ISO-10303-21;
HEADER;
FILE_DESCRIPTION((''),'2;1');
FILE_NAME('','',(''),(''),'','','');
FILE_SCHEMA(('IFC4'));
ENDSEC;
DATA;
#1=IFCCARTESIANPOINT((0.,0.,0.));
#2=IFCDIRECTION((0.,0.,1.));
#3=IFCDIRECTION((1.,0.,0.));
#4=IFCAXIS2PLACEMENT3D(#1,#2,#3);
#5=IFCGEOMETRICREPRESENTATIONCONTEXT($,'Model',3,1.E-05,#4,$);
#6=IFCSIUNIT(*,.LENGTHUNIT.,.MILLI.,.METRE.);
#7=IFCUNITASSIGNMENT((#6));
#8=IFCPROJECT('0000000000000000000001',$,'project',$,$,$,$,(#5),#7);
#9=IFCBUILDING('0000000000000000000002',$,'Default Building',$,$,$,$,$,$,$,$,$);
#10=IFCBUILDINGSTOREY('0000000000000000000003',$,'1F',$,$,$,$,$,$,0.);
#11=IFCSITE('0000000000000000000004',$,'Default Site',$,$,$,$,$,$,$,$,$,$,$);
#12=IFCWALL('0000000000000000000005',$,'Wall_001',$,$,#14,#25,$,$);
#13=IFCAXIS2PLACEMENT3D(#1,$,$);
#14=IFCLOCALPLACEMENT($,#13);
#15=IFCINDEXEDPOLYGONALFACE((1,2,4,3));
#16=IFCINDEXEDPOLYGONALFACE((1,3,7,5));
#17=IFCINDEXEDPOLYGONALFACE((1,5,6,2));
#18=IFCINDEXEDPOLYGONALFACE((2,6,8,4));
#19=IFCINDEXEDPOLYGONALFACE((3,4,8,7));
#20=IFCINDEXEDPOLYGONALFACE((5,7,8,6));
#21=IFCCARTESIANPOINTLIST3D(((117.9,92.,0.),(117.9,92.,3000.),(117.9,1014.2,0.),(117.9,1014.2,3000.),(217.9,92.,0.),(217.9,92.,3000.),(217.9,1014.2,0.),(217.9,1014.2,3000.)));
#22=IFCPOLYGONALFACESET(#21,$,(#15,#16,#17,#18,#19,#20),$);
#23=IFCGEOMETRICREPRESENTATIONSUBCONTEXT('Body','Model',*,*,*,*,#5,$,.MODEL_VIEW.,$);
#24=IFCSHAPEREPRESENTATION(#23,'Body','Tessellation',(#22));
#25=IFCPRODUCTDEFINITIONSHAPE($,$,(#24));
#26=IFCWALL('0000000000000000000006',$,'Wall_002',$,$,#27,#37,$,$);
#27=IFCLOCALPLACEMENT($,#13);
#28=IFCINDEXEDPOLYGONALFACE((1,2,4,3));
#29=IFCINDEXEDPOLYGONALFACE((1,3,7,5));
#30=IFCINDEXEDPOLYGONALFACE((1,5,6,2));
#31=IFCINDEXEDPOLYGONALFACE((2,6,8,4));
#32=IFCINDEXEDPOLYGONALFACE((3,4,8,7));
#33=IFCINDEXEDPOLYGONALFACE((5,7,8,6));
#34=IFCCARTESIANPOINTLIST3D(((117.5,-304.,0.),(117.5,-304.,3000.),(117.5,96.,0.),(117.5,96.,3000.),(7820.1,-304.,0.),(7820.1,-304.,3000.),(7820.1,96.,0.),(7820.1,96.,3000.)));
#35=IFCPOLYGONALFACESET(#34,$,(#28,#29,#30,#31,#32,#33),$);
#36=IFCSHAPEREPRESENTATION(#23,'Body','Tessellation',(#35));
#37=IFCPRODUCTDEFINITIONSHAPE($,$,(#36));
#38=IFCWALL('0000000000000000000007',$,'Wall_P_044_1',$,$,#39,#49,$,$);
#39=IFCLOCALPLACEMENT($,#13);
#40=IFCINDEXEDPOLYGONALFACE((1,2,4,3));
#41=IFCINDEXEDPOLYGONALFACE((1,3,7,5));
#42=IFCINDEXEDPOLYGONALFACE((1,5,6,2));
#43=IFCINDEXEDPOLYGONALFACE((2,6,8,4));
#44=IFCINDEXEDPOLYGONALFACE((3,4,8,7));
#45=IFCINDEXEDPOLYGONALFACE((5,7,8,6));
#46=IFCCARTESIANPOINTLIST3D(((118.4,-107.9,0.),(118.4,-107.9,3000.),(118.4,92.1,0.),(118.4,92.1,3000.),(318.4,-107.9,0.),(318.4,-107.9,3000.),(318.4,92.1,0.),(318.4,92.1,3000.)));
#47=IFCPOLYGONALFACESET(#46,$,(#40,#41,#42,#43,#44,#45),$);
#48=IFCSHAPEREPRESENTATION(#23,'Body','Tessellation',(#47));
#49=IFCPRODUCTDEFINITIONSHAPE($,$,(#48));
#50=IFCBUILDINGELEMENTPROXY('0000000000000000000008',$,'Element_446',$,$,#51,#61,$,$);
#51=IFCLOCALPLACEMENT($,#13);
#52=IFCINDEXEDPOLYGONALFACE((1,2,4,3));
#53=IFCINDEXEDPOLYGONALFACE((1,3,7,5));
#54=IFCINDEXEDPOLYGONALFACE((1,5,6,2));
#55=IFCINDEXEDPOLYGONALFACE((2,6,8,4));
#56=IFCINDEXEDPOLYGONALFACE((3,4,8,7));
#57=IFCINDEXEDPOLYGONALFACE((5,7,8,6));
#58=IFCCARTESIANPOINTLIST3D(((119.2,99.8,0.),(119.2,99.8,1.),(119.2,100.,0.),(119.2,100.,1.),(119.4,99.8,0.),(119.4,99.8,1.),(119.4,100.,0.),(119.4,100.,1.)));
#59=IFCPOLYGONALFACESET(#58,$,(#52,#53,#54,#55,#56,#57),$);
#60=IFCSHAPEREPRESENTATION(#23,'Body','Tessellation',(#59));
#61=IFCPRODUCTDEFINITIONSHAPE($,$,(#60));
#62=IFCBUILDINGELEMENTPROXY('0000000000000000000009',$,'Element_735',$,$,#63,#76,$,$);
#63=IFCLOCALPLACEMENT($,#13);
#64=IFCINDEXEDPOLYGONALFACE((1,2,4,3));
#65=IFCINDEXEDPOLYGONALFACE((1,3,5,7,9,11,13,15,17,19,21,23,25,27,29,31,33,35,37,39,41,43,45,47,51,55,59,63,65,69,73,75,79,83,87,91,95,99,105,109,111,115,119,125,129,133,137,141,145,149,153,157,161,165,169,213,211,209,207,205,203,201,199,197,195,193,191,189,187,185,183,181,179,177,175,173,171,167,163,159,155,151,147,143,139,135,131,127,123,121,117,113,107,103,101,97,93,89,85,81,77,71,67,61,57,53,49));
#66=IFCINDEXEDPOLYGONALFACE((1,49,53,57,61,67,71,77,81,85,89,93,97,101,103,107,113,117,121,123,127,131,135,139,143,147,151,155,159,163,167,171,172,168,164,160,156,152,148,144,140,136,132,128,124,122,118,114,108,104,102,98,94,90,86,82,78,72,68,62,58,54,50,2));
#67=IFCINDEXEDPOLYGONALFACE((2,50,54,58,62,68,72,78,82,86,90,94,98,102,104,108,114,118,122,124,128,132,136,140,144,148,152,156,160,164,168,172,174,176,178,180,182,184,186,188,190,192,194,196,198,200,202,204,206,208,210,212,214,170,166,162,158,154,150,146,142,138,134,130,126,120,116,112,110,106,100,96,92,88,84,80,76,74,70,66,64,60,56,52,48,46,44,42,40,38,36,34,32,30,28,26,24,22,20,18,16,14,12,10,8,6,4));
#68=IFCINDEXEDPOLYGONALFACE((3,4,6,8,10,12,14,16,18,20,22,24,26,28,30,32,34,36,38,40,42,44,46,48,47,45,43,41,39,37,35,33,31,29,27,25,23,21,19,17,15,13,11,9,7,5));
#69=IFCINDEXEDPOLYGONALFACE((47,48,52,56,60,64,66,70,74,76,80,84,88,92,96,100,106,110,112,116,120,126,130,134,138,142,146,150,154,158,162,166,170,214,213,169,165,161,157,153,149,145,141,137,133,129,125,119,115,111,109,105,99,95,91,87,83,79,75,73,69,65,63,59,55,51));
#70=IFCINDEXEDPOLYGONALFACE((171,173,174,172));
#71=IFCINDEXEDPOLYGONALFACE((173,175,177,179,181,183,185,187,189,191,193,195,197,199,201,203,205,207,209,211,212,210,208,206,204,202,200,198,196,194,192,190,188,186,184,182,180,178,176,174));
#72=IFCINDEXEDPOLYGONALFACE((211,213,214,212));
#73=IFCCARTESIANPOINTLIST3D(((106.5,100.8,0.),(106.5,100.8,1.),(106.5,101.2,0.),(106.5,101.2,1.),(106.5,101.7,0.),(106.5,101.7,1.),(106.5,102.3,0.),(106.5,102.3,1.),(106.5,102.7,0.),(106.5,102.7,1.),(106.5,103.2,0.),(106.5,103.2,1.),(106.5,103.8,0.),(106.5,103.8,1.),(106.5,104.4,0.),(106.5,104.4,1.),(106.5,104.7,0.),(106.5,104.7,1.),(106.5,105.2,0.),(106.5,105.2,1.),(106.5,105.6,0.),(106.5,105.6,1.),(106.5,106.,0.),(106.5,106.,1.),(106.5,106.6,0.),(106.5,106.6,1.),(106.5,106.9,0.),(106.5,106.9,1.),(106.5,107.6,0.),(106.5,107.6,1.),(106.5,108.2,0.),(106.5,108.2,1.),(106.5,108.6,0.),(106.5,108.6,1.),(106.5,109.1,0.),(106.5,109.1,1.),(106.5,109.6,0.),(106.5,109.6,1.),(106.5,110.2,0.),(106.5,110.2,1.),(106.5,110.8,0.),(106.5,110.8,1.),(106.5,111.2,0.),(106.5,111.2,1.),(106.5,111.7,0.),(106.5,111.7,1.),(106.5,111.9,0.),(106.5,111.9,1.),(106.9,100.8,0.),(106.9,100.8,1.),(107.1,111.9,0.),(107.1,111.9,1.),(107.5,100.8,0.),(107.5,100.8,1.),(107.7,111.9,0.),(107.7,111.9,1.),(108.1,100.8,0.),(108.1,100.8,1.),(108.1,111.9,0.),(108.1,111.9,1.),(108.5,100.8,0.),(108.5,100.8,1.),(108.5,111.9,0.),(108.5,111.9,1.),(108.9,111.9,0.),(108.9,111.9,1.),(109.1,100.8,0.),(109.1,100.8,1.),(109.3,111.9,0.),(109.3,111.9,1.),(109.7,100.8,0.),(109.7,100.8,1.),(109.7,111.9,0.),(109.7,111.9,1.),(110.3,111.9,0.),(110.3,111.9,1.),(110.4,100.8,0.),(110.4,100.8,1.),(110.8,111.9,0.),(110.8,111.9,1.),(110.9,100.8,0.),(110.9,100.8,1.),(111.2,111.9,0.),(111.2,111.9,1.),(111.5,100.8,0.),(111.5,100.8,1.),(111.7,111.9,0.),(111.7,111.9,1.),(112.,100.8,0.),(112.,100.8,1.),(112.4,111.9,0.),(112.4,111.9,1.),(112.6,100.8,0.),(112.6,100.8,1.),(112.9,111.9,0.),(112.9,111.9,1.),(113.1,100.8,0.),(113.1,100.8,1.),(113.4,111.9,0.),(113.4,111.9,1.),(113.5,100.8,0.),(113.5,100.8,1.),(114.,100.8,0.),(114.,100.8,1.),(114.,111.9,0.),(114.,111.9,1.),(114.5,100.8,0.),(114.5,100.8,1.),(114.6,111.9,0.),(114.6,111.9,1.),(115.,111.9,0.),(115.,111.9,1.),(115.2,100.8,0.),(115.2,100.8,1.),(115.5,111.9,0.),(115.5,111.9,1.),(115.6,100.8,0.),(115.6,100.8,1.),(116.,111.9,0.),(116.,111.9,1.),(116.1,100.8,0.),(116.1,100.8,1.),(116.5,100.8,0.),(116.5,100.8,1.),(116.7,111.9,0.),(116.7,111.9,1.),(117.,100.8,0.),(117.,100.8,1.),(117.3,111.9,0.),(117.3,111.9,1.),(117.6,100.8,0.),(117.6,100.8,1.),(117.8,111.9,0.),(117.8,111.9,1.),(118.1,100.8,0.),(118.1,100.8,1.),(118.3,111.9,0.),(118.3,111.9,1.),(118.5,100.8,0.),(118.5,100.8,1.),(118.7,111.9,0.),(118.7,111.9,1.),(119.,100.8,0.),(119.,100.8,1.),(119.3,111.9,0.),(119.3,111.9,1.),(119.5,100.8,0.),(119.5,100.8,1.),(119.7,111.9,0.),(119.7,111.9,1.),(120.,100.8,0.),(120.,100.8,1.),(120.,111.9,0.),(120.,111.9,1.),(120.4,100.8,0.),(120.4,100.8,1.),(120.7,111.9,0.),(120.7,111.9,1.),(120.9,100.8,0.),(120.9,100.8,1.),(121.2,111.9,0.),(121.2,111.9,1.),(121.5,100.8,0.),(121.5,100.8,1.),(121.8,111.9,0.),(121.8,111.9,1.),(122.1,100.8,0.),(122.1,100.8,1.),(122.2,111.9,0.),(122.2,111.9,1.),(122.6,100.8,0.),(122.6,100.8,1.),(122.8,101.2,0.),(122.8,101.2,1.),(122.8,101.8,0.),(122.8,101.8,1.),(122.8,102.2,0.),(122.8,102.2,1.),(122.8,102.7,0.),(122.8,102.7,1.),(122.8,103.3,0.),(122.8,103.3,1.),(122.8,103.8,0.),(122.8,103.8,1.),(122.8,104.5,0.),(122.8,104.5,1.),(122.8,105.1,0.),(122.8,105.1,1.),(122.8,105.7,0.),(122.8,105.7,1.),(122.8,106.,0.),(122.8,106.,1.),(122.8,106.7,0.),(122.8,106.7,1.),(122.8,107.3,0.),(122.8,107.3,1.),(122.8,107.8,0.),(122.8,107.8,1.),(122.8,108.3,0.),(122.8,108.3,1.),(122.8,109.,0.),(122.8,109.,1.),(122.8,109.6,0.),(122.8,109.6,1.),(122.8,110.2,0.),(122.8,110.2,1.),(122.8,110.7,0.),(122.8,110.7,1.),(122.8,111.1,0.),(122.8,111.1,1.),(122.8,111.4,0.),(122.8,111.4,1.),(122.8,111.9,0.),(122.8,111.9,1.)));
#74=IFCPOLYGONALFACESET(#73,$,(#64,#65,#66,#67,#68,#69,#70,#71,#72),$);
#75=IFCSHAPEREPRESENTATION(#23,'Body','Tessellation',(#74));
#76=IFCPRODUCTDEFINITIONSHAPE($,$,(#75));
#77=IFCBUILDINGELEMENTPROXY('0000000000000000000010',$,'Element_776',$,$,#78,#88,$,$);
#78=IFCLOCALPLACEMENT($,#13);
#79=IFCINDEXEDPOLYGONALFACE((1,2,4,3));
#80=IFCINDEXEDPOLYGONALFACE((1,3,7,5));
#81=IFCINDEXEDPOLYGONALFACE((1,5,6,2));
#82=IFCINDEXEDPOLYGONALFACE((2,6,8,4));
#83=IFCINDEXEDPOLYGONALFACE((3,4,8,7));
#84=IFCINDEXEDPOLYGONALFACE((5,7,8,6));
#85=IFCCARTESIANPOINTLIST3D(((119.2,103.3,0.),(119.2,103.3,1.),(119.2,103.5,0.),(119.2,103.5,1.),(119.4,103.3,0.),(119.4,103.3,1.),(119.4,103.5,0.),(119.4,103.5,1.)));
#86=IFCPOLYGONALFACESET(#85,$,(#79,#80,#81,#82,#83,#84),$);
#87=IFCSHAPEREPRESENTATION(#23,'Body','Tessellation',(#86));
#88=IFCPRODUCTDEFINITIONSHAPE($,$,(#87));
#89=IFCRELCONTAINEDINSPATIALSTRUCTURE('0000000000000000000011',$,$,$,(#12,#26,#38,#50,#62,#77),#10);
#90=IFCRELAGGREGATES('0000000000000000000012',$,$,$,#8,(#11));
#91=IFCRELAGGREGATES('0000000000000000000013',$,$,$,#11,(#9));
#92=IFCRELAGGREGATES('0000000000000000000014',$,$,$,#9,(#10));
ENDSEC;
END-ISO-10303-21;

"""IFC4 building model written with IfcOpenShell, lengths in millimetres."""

from ifc_helpers import new_model, si_unit, frame, origin, origin_with_axes, place, context, subcontext, project, spatial, polyline, indexed_curve, outline, extrude, element, save


model = new_model("IFC4")

# Units and contexts
model_context = context("Model", 3, precision=1e-05, world=origin_with_axes())
body_context = subcontext(model_context, "Body", "Model", "MODEL_VIEW")
ifc_project = project(units=[si_unit("LENGTHUNIT", "METRE", prefix="MILLI")], contexts=[model_context])

# Site, building, storey
site = spatial("IfcSite", under=ifc_project, Name="Default Site")
building = spatial("IfcBuilding", under=site, Name="Default Building")
storey = spatial("IfcBuildingStorey", under=building, Name="1F", Elevation=0.0)

# Walls
wall_1_placement = place(None, frame((117.9, 92.0, 0.0), z_axis=(0.0, 0.0, 1.0), x_axis=(1.0, 0.0, 0.0)))
element("IfcWall", 1, at=wall_1_placement, inside=storey, Name="Wall_001", context=body_context, shape_type="SweptSolid", body=[
    extrude(outline(indexed_curve([(0.0, 0.0), (0.0, 922.2), (100.0, 922.2), (100.0, 0.0), (0.0, 0.0)], self_intersect=False)), origin_with_axes(), (0.0, 0.0, 1.0), 3000.0),
])
wall_2_placement = place(None, frame((117.5, 96.0, 0.0), z_axis=(0.0, 0.0, 1.0), x_axis=(0.0, -1.0, 0.0)))
element("IfcWall", 2, at=wall_2_placement, inside=storey, Name="Wall_002", context=body_context, shape_type="SweptSolid", body=[
    extrude(outline(indexed_curve([(0.0, 0.0), (0.0, 7702.6), (400.0, 7702.6), (400.0, 0.0), (0.0, 0.0)], self_intersect=False)), origin_with_axes(), (0.0, 0.0, 1.0), 3000.0),
])
wall_3_placement = place(None, frame((118.4, 92.1, 0.0), z_axis=(0.0, 0.0, 1.0), x_axis=(0.0, -1.0, 0.0)))
element("IfcWall", 3, at=wall_3_placement, inside=storey, Name="Wall_P_044_1", context=body_context, shape_type="SweptSolid", body=[
    extrude(outline(indexed_curve([(0.0, 0.0), (0.0, 200.0), (200.0, 200.0), (200.0, 0.0), (0.0, 0.0)], self_intersect=False)), origin_with_axes(), (0.0, 0.0, 1.0), 3000.0),
])

# Building element proxies
proxy_1_placement = place(None, frame((119.3, 99.9, 0.0), z_axis=(0.0, 0.0, 1.0), x_axis=(1.0, 0.0, 0.0)))
element("IfcBuildingElementProxy", 4, at=proxy_1_placement, inside=storey, Name="Element_446", context=body_context, shape_type="SweptSolid", body=[
    extrude(outline(polyline([(-0.1, 0.1), (0.1, 0.1), (0.1, -0.1), (-0.1, -0.1), (-0.1, 0.1)])), origin(), (0.0, 0.0, 1.0), 1.0),
])
proxy_2_placement = place(None, frame((114.5, 106.4, 0.0), z_axis=(0.0, 0.0, 1.0), x_axis=(1.0, 0.0, 0.0)))
element("IfcBuildingElementProxy", 5, at=proxy_2_placement, inside=storey, Name="Element_735", context=body_context, shape_type="SweptSolid", body=[
    extrude(outline(polyline([(-8.0, 5.5), (-7.4, 5.5), (-6.7, 5.5), (-6.3, 5.5), (-6.0, 5.5), (-5.6, 5.5), (-5.2, 5.5), (-4.8, 5.5), (-4.2, 5.5), (-3.7, 5.5), (-3.2, 5.5), (-2.7, 5.5), (-2.1, 5.5), (-1.6, 5.5), (-1.0, 5.5), (-0.4, 5.5), (0.1, 5.5), (0.6, 5.5), (1.1, 5.5), (1.6, 5.5), (2.2, 5.5), (2.8, 5.5), (3.4, 5.5), (3.8, 5.5), (4.2, 5.5), (4.8, 5.5), (5.2, 5.5), (5.6, 5.5), (6.2, 5.5), (6.7, 5.5), (7.4, 5.5), (7.8, 5.5), (8.3, 5.5), (8.4, 5.0), (8.4, 4.6), (8.4, 4.3), (8.4, 3.7), (8.4, 3.2), (8.4, 2.5), (8.4, 1.9), (8.4, 1.3), (8.4, 0.8), (8.4, 0.2), (8.4, -0.4), (8.4, -0.8), (8.4, -1.4), (8.4, -2.0), (8.4, -2.6), (8.4, -3.2), (8.4, -3.8), (8.4, -4.2), (8.4, -4.6), (8.4, -5.3), (8.1, -5.6), (7.6, -5.6), (7.0, -5.6), (6.4, -5.6), (5.9, -5.6), (5.6, -5.6), (5.0, -5.6), (4.6, -5.6), (4.1, -5.6), (3.6, -5.6), (3.1, -5.6), (2.5, -5.6), (2.0, -5.6), (1.7, -5.6), (1.2, -5.6), (0.7, -5.6), (0.1, -5.6), (-0.4, -5.6), (-1.0, -5.6), (-1.4, -5.6), (-1.9, -5.6), (-2.5, -5.6), (-2.9, -5.6), (-3.5, -5.6), (-4.1, -5.6), (-4.7, -5.6), (-5.4, -5.6), (-5.9, -5.6), (-6.4, -5.6), (-7.0, -5.6), (-7.5, -5.6), (-8.0, -5.6), (-8.0, -5.3), (-8.0, -4.7), (-8.0, -4.1), (-8.0, -3.8), (-8.0, -3.3), (-8.0, -2.7), (-8.0, -2.1), (-8.0, -1.7), (-8.0, -1.2), (-8.0, -0.8), (-8.0, -0.4), (-8.0, 0.1), (-8.0, 0.5), (-8.0, 1.1), (-8.0, 1.7), (-8.0, 2.1), (-8.0, 2.6), (-8.0, 3.1), (-8.0, 3.8), (-8.0, 4.4), (-8.0, 4.8), (-8.0, 5.3), (-8.0, 5.5)])), origin(), (0.0, 0.0, 1.0), 1.0),
])
proxy_3_placement = place(None, frame((119.3, 103.4, 0.0), z_axis=(0.0, 0.0, 1.0), x_axis=(1.0, 0.0, 0.0)))
element("IfcBuildingElementProxy", 6, at=proxy_3_placement, inside=storey, Name="Element_776", context=body_context, shape_type="SweptSolid", body=[
    extrude(outline(polyline([(-0.1, 0.1), (0.1, 0.1), (0.1, -0.1), (-0.1, -0.1), (-0.1, 0.1)])), origin(), (0.0, 0.0, 1.0), 1.0),
])

save(model, "model.ifc")
